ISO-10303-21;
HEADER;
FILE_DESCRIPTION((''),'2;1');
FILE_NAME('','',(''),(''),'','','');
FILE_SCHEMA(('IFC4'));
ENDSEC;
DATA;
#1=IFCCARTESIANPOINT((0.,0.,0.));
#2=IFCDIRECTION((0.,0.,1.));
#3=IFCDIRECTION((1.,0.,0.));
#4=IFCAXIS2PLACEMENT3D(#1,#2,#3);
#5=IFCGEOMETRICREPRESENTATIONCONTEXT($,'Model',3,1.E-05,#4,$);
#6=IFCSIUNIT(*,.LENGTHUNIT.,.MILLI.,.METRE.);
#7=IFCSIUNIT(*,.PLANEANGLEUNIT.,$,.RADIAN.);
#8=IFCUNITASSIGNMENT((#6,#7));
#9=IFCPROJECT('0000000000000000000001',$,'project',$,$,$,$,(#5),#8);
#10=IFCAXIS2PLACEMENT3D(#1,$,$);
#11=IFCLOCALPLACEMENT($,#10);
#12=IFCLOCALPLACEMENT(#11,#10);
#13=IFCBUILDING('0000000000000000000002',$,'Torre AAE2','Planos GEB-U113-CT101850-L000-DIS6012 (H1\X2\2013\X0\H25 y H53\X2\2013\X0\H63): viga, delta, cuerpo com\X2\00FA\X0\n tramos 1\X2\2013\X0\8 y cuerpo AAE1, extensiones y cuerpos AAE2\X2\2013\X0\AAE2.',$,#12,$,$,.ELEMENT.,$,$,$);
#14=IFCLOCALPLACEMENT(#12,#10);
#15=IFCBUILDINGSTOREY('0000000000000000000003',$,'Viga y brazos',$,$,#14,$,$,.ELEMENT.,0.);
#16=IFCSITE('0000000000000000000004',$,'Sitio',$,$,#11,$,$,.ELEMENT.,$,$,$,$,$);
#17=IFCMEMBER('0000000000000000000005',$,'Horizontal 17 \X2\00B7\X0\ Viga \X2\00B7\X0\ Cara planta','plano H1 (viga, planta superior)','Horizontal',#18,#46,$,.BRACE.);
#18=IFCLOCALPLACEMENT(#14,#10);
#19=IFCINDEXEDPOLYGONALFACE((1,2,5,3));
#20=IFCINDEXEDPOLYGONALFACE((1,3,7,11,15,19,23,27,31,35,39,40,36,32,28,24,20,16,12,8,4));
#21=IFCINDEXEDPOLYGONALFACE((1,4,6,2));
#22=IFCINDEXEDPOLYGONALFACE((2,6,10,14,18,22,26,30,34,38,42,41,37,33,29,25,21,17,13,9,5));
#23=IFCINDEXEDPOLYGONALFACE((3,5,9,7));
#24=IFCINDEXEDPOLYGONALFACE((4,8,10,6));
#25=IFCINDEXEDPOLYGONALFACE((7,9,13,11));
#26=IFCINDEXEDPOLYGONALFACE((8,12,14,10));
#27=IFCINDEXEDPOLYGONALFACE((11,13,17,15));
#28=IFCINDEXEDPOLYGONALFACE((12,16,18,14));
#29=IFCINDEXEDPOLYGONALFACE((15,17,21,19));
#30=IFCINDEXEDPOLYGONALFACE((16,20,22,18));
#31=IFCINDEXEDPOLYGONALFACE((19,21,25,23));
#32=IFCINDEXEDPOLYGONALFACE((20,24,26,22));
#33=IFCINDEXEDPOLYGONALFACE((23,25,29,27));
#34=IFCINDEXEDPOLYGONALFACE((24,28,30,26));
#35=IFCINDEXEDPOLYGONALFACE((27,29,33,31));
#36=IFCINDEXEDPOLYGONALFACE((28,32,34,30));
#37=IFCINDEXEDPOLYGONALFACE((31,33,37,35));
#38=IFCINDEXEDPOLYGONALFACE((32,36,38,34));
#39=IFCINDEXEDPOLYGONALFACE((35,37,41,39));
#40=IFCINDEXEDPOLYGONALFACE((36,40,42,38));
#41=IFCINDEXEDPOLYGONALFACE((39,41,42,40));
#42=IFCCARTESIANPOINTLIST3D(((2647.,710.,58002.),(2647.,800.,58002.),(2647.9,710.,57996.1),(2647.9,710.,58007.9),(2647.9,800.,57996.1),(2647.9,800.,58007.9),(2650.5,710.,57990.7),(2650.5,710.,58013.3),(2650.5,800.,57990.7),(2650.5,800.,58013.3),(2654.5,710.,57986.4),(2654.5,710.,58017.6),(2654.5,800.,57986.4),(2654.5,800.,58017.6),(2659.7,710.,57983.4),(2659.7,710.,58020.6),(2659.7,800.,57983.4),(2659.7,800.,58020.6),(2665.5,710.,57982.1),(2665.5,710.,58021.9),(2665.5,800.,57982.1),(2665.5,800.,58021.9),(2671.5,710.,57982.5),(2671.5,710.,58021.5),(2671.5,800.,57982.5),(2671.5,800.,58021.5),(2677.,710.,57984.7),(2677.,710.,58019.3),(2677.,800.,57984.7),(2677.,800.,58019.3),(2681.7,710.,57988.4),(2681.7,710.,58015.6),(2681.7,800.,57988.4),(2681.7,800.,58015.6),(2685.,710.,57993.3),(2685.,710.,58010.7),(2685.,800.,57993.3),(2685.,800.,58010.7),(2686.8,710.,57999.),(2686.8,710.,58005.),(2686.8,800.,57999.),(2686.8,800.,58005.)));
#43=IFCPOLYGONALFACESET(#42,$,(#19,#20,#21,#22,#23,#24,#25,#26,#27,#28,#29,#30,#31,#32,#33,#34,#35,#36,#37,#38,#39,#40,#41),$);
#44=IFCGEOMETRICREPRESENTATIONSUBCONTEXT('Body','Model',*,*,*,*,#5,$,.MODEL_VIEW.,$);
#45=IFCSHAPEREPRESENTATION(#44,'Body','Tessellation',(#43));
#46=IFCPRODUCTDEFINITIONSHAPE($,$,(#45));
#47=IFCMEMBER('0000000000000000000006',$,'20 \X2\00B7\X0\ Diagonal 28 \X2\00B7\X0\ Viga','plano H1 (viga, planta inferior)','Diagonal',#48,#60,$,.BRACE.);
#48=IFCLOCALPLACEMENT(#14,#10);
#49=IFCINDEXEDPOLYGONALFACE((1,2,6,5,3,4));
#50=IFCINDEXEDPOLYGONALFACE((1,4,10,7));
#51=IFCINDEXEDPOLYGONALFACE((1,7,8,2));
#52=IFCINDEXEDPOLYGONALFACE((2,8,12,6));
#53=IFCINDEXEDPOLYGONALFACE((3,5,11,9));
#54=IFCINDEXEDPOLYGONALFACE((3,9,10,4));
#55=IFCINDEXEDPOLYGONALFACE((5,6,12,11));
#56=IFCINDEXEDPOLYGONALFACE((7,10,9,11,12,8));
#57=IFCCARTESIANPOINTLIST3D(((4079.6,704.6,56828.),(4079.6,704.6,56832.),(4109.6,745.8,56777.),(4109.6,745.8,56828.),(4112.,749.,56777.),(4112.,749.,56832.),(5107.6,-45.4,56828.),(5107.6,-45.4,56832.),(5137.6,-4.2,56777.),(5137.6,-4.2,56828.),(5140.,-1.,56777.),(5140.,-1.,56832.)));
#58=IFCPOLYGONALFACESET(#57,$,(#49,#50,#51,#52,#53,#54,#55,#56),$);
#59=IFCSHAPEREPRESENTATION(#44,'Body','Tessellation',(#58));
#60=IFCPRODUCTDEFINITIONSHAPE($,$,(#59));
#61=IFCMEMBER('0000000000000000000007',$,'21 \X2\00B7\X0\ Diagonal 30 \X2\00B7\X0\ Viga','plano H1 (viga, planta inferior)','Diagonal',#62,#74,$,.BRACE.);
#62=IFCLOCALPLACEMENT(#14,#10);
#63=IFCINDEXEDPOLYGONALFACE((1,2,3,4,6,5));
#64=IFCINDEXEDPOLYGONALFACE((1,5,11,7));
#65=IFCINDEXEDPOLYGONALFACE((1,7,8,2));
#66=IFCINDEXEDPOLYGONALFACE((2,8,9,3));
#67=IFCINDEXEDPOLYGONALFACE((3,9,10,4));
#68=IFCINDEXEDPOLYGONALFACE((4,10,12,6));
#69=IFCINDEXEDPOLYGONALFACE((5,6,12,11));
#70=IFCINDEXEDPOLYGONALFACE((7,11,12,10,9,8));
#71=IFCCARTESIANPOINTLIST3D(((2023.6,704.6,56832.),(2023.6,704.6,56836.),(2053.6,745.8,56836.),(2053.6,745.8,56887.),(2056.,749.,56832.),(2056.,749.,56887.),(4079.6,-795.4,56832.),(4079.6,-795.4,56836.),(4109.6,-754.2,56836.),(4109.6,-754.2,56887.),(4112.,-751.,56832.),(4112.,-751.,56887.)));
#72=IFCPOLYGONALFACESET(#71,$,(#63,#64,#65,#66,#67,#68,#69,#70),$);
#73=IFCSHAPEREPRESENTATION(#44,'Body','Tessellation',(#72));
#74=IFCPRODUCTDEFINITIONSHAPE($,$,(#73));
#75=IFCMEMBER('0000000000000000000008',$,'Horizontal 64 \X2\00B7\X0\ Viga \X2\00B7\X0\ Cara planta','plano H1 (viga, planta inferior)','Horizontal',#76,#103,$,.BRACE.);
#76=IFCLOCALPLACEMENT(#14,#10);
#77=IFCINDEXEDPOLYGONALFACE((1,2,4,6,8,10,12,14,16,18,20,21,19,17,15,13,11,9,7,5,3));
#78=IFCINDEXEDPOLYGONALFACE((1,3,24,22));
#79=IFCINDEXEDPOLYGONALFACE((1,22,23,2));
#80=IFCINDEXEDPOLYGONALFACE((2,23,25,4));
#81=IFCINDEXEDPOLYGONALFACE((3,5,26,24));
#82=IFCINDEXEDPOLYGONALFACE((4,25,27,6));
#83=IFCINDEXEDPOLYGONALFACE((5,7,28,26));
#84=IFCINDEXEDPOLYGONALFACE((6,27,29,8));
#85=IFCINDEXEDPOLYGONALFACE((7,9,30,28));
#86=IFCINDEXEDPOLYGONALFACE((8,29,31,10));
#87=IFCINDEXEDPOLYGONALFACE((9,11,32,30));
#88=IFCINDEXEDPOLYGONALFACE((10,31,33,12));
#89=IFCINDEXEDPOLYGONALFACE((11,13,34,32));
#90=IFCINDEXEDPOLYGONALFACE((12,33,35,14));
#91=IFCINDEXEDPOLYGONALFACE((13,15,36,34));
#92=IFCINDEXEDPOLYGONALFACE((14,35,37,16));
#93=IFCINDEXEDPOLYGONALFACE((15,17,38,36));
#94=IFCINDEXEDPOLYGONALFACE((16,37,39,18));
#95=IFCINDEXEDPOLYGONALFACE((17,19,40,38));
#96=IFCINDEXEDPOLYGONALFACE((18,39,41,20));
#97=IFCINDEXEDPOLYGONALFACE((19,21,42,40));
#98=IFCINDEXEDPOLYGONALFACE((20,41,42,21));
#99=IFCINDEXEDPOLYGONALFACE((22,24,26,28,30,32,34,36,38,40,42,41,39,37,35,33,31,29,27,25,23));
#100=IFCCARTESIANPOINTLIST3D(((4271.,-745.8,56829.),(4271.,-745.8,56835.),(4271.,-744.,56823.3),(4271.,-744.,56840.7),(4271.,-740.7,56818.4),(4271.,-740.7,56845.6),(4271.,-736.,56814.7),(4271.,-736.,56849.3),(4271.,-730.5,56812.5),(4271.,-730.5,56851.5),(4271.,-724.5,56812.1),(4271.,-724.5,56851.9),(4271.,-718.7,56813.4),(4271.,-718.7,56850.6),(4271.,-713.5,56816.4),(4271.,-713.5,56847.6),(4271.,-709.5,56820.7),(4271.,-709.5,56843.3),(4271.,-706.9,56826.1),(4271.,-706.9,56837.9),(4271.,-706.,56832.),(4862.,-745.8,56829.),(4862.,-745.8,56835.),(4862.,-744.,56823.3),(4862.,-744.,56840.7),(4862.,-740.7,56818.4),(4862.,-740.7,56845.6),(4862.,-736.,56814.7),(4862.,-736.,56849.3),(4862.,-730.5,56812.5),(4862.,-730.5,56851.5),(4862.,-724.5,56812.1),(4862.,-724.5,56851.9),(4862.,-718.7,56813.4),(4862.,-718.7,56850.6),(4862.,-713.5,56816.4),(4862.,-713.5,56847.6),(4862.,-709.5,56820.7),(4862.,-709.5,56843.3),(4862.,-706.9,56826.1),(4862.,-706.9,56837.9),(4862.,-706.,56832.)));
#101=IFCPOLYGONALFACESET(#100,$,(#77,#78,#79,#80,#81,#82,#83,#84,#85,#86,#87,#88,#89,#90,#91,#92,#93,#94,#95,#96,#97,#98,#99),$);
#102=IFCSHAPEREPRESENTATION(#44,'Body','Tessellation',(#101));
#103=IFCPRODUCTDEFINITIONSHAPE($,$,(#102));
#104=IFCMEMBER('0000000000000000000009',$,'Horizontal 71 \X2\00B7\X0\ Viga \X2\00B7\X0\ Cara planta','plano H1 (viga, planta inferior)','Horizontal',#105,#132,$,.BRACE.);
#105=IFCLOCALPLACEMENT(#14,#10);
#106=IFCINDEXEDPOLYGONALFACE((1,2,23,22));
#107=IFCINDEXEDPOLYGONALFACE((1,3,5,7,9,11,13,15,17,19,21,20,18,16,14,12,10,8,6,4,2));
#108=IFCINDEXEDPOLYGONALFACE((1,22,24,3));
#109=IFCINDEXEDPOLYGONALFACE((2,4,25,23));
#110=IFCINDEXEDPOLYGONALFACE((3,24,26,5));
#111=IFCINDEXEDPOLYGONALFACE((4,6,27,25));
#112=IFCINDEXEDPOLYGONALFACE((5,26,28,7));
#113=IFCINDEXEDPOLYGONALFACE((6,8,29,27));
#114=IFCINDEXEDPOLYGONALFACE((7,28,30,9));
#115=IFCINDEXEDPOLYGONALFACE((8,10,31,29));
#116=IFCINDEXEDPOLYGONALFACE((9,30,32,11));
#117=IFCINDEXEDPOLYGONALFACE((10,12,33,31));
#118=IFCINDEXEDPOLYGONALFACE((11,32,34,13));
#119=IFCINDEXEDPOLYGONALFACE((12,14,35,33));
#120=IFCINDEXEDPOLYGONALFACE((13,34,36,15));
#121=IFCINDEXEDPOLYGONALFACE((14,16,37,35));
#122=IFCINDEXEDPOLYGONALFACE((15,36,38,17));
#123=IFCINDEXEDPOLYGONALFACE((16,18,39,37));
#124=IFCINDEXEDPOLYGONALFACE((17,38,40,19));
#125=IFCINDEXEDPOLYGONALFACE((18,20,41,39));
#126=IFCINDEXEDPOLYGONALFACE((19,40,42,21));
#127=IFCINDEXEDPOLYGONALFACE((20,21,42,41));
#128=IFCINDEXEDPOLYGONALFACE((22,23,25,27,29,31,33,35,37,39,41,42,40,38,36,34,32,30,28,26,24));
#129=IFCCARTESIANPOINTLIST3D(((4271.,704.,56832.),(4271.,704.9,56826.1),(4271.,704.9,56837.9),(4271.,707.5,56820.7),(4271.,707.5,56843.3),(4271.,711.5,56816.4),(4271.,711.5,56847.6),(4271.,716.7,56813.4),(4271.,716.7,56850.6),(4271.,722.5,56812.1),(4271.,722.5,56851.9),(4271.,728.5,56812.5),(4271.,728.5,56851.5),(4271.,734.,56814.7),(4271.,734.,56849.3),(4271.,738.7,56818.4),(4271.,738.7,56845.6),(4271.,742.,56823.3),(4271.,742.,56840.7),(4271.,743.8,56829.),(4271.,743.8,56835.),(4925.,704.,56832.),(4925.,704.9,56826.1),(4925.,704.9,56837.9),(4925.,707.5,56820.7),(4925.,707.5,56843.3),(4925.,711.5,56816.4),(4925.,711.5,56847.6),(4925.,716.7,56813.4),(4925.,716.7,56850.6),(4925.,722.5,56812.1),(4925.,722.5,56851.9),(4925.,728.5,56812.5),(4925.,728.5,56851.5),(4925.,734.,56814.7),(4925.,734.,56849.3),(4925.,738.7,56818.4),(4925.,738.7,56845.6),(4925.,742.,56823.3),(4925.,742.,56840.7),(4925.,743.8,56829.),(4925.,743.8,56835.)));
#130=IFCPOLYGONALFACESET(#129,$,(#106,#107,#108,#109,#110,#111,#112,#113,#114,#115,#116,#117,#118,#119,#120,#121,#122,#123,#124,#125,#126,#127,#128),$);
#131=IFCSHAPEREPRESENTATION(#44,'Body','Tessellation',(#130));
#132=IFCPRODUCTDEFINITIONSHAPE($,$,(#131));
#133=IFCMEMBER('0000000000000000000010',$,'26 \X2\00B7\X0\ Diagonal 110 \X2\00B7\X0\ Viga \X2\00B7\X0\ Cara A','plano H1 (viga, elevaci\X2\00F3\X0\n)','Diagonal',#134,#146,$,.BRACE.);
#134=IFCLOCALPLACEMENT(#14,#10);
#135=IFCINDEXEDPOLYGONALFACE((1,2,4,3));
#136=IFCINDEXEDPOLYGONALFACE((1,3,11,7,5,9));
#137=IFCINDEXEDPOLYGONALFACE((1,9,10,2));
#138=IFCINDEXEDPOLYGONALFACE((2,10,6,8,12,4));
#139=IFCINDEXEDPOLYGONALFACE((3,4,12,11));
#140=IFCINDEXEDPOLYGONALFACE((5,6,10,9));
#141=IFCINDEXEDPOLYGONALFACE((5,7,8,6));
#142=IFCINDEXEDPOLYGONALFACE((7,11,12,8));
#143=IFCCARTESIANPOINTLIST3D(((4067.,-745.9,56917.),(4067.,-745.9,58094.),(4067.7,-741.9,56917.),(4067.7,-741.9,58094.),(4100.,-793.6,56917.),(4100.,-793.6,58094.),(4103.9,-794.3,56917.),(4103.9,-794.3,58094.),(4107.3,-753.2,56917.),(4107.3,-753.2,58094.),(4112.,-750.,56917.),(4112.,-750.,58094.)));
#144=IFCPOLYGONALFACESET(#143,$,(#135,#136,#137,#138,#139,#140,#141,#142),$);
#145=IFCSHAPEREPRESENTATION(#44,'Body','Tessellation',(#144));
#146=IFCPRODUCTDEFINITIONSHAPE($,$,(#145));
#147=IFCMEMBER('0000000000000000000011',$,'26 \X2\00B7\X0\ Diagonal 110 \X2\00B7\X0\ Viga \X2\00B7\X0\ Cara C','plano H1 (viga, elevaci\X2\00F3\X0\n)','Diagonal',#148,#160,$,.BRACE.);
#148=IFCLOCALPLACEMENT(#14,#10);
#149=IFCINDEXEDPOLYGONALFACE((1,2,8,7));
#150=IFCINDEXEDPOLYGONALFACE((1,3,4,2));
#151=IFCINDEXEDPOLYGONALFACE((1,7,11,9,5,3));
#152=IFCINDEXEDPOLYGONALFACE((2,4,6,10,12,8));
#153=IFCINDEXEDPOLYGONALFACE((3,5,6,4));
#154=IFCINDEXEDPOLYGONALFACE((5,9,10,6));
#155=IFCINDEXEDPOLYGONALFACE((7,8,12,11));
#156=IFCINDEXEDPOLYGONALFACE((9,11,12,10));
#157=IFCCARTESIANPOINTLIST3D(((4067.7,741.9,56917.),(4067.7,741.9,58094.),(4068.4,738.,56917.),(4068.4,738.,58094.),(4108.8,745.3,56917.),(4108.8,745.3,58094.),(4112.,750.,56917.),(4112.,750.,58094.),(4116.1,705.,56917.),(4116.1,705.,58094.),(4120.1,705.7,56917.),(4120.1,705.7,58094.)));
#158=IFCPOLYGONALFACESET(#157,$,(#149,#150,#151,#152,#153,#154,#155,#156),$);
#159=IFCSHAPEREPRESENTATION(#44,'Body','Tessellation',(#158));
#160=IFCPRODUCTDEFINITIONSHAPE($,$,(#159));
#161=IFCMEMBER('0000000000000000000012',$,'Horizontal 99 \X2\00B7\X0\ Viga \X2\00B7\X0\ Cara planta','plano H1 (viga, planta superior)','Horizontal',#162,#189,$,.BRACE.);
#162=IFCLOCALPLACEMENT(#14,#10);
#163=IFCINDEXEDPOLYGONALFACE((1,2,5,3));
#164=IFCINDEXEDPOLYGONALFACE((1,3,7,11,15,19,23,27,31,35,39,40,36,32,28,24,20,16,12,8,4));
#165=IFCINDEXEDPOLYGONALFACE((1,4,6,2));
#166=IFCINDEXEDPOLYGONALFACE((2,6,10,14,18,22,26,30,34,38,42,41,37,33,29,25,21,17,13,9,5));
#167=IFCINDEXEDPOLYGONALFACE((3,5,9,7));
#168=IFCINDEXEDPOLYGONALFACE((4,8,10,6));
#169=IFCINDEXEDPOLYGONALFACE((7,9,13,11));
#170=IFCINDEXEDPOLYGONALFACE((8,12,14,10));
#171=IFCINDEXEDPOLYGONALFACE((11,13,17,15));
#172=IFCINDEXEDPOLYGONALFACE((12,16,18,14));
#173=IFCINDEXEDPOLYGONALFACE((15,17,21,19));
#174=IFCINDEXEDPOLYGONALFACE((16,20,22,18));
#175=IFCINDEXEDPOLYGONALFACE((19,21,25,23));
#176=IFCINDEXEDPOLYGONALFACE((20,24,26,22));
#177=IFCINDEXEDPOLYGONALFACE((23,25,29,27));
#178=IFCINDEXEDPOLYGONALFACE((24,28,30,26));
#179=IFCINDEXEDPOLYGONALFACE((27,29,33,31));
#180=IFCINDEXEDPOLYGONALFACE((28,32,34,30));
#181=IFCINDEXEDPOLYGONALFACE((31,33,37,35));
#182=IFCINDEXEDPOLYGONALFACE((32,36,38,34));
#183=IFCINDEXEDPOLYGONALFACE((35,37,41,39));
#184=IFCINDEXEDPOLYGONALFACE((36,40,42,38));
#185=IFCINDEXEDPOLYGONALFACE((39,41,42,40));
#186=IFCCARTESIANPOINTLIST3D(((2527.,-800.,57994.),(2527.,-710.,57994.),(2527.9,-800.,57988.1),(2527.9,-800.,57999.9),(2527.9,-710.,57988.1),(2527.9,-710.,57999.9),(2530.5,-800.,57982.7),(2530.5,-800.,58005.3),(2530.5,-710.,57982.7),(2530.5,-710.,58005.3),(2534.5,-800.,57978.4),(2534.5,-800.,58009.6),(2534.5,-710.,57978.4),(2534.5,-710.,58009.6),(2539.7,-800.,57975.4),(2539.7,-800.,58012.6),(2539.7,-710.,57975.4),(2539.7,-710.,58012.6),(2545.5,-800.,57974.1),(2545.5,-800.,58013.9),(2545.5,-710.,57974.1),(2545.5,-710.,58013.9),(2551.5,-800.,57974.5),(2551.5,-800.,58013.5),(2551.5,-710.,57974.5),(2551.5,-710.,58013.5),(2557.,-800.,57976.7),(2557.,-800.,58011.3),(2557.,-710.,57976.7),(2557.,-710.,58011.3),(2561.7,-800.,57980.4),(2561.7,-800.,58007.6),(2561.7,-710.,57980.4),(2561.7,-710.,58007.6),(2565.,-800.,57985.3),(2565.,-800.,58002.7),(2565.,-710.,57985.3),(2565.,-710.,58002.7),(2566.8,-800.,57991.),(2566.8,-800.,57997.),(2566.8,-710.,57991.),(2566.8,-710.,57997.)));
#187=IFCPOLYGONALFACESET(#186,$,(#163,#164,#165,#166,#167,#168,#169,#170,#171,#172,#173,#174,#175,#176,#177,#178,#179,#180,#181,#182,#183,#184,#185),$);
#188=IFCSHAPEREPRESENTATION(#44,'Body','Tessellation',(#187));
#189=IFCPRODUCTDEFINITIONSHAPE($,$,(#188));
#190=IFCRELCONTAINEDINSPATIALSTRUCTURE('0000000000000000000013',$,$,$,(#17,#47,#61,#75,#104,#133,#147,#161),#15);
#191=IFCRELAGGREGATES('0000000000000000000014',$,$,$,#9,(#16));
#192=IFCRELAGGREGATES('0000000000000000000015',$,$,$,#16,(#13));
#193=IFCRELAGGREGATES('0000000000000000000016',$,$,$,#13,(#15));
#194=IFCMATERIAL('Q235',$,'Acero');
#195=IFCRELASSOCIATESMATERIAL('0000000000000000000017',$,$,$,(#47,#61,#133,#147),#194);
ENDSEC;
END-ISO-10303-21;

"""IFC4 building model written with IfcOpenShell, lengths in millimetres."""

from ifc_helpers import new_model, si_unit, frame, frame_2d, origin, origin_with_axes, place, context, subcontext, project, spatial, circle, l_section, extrude, material, element, save


model = new_model("IFC4")

# Units and contexts
model_context = context("Model", 3, precision=1e-05, world=origin_with_axes())
body_context = subcontext(model_context, "Body", "Model", "MODEL_VIEW")
ifc_project = project(units=[si_unit("LENGTHUNIT", "METRE", prefix="MILLI"), si_unit("PLANEANGLEUNIT", "RADIAN")], contexts=[model_context])

# Site, building, storey
site_placement = place(None, origin())
site = spatial("IfcSite", under=ifc_project, at=site_placement, Name="Sitio", CompositionType="ELEMENT")
building_placement = place(site_placement, origin())
building = spatial("IfcBuilding", under=site, at=building_placement, Name="Torre AAE2", Description="Planos GEB-U113-CT101850-L000-DIS6012 (H1–H25 y H53–H63): viga, delta, cuerpo común tramos 1–8 y cuerpo AAE1, extensiones y cuerpos AAE2–AAE2.", CompositionType="ELEMENT")
storey_placement = place(building_placement, origin())
storey = spatial("IfcBuildingStorey", under=building, at=storey_placement, Name="Viga y brazos", CompositionType="ELEMENT", Elevation=0.0)

# Members
ifc_material = material(Name="Q235", Category="Acero")
for number, where, z_axis, x_axis, name in (
    (1, (2667.0, 710.0, 58002.0), (0.0, 1.0, 0.0), (-1.0, 0.0, 0.0), "Horizontal 17 · Viga · Cara planta"),
):
    element("IfcMember", number, at=place(storey_placement, frame(where, z_axis=z_axis, x_axis=x_axis)), inside=storey, Name=name, Description="plano H1 (viga, planta superior)", ObjectType="Horizontal", PredefinedType="BRACE", context=body_context, shape_type="SweptSolid", body=[
        extrude(circle(Radius=20.0), None, (0.0, 0.0, 1.0), 90.0),
    ])
member_1_placement = place(storey_placement, frame((4112.0, 749.0, 56832.0), z_axis=(0.807852, -0.589386, 0.0), x_axis=(-0.589386, -0.807852, 0.0)))
element("IfcMember", 2, at=member_1_placement, inside=storey, material=ifc_material, Name="20 · Diagonal 28 · Viga", Description="plano H1 (viga, planta inferior)", ObjectType="Diagonal", PredefinedType="BRACE", context=body_context, shape_type="SweptSolid", body=[
    extrude(l_section(Depth=55.0, Width=55.0, Thickness=4.0, at=frame_2d((27.5, 27.5))), None, (0.0, 0.0, 1.0), 1272.5),
])
member_2_placement = place(storey_placement, frame((4112.0, -751.0, 56832.0), z_axis=(-0.807852, 0.589386, 0.0), x_axis=(-0.589386, -0.807852, 0.0)))
element("IfcMember", 3, at=member_2_placement, inside=storey, material=ifc_material, Name="21 · Diagonal 30 · Viga", Description="plano H1 (viga, planta inferior)", ObjectType="Diagonal", PredefinedType="BRACE", context=body_context, shape_type="SweptSolid", body=[
    extrude(l_section(Depth=55.0, Width=55.0, Thickness=4.0, at=frame_2d((27.5, 27.5))), None, (0.0, 0.0, 1.0), 2545.0),
])
member_3_placement = place(storey_placement, frame((4271.0, -726.0, 56832.0), z_axis=(1.0, 0.0, 0.0), x_axis=(0.0, 1.0, 0.0)))
element("IfcMember", 4, at=member_3_placement, inside=storey, Name="Horizontal 64 · Viga · Cara planta", Description="plano H1 (viga, planta inferior)", ObjectType="Horizontal", PredefinedType="BRACE", context=body_context, shape_type="SweptSolid", body=[
    extrude(circle(Radius=20.0), None, (0.0, 0.0, 1.0), 591.0),
])
member_4_placement = place(storey_placement, frame((4271.0, 724.0, 56832.0), z_axis=(1.0, 0.0, 0.0), x_axis=(0.0, -1.0, 0.0)))
element("IfcMember", 5, at=member_4_placement, inside=storey, Name="Horizontal 71 · Viga · Cara planta", Description="plano H1 (viga, planta inferior)", ObjectType="Horizontal", PredefinedType="BRACE", context=body_context, shape_type="SweptSolid", body=[
    extrude(circle(Radius=20.0), None, (0.0, 0.0, 1.0), 654.0),
])
for number, where, z_axis, x_axis, name in (
    (6, (4112.0, -750.0, 56917.0), (0.0, 0.0, 1.0), (-0.98377, 0.179433, 0.0), "26 · Diagonal 110 · Viga · Cara A"),
    (7, (4112.0, 750.0, 56917.0), (0.0, 0.0, 1.0), (-0.98377, -0.179433, 0.0), "26 · Diagonal 110 · Viga · Cara C"),
):
    element("IfcMember", number, at=place(storey_placement, frame(where, z_axis=z_axis, x_axis=x_axis)), inside=storey, material=ifc_material, Name=name, Description="plano H1 (viga, elevación)", ObjectType="Diagonal", PredefinedType="BRACE", context=body_context, shape_type="SweptSolid", body=[
        extrude(l_section(Depth=45.0, Width=45.0, Thickness=4.0, at=frame_2d((22.5, 22.5))), None, (0.0, 0.0, 1.0), 1177.0),
    ])
for number, where, z_axis, x_axis, name in (
    (8, (2547.0, -710.0, 57994.0), (0.0, -1.0, 0.0), (-1.0, 0.0, 0.0), "Horizontal 99 · Viga · Cara planta"),
):
    element("IfcMember", number, at=place(storey_placement, frame(where, z_axis=z_axis, x_axis=x_axis)), inside=storey, Name=name, Description="plano H1 (viga, planta superior)", ObjectType="Horizontal", PredefinedType="BRACE", context=body_context, shape_type="SweptSolid", body=[
        extrude(circle(Radius=20.0), None, (0.0, 0.0, 1.0), 90.0),
    ])

save(model, "model.ifc")
